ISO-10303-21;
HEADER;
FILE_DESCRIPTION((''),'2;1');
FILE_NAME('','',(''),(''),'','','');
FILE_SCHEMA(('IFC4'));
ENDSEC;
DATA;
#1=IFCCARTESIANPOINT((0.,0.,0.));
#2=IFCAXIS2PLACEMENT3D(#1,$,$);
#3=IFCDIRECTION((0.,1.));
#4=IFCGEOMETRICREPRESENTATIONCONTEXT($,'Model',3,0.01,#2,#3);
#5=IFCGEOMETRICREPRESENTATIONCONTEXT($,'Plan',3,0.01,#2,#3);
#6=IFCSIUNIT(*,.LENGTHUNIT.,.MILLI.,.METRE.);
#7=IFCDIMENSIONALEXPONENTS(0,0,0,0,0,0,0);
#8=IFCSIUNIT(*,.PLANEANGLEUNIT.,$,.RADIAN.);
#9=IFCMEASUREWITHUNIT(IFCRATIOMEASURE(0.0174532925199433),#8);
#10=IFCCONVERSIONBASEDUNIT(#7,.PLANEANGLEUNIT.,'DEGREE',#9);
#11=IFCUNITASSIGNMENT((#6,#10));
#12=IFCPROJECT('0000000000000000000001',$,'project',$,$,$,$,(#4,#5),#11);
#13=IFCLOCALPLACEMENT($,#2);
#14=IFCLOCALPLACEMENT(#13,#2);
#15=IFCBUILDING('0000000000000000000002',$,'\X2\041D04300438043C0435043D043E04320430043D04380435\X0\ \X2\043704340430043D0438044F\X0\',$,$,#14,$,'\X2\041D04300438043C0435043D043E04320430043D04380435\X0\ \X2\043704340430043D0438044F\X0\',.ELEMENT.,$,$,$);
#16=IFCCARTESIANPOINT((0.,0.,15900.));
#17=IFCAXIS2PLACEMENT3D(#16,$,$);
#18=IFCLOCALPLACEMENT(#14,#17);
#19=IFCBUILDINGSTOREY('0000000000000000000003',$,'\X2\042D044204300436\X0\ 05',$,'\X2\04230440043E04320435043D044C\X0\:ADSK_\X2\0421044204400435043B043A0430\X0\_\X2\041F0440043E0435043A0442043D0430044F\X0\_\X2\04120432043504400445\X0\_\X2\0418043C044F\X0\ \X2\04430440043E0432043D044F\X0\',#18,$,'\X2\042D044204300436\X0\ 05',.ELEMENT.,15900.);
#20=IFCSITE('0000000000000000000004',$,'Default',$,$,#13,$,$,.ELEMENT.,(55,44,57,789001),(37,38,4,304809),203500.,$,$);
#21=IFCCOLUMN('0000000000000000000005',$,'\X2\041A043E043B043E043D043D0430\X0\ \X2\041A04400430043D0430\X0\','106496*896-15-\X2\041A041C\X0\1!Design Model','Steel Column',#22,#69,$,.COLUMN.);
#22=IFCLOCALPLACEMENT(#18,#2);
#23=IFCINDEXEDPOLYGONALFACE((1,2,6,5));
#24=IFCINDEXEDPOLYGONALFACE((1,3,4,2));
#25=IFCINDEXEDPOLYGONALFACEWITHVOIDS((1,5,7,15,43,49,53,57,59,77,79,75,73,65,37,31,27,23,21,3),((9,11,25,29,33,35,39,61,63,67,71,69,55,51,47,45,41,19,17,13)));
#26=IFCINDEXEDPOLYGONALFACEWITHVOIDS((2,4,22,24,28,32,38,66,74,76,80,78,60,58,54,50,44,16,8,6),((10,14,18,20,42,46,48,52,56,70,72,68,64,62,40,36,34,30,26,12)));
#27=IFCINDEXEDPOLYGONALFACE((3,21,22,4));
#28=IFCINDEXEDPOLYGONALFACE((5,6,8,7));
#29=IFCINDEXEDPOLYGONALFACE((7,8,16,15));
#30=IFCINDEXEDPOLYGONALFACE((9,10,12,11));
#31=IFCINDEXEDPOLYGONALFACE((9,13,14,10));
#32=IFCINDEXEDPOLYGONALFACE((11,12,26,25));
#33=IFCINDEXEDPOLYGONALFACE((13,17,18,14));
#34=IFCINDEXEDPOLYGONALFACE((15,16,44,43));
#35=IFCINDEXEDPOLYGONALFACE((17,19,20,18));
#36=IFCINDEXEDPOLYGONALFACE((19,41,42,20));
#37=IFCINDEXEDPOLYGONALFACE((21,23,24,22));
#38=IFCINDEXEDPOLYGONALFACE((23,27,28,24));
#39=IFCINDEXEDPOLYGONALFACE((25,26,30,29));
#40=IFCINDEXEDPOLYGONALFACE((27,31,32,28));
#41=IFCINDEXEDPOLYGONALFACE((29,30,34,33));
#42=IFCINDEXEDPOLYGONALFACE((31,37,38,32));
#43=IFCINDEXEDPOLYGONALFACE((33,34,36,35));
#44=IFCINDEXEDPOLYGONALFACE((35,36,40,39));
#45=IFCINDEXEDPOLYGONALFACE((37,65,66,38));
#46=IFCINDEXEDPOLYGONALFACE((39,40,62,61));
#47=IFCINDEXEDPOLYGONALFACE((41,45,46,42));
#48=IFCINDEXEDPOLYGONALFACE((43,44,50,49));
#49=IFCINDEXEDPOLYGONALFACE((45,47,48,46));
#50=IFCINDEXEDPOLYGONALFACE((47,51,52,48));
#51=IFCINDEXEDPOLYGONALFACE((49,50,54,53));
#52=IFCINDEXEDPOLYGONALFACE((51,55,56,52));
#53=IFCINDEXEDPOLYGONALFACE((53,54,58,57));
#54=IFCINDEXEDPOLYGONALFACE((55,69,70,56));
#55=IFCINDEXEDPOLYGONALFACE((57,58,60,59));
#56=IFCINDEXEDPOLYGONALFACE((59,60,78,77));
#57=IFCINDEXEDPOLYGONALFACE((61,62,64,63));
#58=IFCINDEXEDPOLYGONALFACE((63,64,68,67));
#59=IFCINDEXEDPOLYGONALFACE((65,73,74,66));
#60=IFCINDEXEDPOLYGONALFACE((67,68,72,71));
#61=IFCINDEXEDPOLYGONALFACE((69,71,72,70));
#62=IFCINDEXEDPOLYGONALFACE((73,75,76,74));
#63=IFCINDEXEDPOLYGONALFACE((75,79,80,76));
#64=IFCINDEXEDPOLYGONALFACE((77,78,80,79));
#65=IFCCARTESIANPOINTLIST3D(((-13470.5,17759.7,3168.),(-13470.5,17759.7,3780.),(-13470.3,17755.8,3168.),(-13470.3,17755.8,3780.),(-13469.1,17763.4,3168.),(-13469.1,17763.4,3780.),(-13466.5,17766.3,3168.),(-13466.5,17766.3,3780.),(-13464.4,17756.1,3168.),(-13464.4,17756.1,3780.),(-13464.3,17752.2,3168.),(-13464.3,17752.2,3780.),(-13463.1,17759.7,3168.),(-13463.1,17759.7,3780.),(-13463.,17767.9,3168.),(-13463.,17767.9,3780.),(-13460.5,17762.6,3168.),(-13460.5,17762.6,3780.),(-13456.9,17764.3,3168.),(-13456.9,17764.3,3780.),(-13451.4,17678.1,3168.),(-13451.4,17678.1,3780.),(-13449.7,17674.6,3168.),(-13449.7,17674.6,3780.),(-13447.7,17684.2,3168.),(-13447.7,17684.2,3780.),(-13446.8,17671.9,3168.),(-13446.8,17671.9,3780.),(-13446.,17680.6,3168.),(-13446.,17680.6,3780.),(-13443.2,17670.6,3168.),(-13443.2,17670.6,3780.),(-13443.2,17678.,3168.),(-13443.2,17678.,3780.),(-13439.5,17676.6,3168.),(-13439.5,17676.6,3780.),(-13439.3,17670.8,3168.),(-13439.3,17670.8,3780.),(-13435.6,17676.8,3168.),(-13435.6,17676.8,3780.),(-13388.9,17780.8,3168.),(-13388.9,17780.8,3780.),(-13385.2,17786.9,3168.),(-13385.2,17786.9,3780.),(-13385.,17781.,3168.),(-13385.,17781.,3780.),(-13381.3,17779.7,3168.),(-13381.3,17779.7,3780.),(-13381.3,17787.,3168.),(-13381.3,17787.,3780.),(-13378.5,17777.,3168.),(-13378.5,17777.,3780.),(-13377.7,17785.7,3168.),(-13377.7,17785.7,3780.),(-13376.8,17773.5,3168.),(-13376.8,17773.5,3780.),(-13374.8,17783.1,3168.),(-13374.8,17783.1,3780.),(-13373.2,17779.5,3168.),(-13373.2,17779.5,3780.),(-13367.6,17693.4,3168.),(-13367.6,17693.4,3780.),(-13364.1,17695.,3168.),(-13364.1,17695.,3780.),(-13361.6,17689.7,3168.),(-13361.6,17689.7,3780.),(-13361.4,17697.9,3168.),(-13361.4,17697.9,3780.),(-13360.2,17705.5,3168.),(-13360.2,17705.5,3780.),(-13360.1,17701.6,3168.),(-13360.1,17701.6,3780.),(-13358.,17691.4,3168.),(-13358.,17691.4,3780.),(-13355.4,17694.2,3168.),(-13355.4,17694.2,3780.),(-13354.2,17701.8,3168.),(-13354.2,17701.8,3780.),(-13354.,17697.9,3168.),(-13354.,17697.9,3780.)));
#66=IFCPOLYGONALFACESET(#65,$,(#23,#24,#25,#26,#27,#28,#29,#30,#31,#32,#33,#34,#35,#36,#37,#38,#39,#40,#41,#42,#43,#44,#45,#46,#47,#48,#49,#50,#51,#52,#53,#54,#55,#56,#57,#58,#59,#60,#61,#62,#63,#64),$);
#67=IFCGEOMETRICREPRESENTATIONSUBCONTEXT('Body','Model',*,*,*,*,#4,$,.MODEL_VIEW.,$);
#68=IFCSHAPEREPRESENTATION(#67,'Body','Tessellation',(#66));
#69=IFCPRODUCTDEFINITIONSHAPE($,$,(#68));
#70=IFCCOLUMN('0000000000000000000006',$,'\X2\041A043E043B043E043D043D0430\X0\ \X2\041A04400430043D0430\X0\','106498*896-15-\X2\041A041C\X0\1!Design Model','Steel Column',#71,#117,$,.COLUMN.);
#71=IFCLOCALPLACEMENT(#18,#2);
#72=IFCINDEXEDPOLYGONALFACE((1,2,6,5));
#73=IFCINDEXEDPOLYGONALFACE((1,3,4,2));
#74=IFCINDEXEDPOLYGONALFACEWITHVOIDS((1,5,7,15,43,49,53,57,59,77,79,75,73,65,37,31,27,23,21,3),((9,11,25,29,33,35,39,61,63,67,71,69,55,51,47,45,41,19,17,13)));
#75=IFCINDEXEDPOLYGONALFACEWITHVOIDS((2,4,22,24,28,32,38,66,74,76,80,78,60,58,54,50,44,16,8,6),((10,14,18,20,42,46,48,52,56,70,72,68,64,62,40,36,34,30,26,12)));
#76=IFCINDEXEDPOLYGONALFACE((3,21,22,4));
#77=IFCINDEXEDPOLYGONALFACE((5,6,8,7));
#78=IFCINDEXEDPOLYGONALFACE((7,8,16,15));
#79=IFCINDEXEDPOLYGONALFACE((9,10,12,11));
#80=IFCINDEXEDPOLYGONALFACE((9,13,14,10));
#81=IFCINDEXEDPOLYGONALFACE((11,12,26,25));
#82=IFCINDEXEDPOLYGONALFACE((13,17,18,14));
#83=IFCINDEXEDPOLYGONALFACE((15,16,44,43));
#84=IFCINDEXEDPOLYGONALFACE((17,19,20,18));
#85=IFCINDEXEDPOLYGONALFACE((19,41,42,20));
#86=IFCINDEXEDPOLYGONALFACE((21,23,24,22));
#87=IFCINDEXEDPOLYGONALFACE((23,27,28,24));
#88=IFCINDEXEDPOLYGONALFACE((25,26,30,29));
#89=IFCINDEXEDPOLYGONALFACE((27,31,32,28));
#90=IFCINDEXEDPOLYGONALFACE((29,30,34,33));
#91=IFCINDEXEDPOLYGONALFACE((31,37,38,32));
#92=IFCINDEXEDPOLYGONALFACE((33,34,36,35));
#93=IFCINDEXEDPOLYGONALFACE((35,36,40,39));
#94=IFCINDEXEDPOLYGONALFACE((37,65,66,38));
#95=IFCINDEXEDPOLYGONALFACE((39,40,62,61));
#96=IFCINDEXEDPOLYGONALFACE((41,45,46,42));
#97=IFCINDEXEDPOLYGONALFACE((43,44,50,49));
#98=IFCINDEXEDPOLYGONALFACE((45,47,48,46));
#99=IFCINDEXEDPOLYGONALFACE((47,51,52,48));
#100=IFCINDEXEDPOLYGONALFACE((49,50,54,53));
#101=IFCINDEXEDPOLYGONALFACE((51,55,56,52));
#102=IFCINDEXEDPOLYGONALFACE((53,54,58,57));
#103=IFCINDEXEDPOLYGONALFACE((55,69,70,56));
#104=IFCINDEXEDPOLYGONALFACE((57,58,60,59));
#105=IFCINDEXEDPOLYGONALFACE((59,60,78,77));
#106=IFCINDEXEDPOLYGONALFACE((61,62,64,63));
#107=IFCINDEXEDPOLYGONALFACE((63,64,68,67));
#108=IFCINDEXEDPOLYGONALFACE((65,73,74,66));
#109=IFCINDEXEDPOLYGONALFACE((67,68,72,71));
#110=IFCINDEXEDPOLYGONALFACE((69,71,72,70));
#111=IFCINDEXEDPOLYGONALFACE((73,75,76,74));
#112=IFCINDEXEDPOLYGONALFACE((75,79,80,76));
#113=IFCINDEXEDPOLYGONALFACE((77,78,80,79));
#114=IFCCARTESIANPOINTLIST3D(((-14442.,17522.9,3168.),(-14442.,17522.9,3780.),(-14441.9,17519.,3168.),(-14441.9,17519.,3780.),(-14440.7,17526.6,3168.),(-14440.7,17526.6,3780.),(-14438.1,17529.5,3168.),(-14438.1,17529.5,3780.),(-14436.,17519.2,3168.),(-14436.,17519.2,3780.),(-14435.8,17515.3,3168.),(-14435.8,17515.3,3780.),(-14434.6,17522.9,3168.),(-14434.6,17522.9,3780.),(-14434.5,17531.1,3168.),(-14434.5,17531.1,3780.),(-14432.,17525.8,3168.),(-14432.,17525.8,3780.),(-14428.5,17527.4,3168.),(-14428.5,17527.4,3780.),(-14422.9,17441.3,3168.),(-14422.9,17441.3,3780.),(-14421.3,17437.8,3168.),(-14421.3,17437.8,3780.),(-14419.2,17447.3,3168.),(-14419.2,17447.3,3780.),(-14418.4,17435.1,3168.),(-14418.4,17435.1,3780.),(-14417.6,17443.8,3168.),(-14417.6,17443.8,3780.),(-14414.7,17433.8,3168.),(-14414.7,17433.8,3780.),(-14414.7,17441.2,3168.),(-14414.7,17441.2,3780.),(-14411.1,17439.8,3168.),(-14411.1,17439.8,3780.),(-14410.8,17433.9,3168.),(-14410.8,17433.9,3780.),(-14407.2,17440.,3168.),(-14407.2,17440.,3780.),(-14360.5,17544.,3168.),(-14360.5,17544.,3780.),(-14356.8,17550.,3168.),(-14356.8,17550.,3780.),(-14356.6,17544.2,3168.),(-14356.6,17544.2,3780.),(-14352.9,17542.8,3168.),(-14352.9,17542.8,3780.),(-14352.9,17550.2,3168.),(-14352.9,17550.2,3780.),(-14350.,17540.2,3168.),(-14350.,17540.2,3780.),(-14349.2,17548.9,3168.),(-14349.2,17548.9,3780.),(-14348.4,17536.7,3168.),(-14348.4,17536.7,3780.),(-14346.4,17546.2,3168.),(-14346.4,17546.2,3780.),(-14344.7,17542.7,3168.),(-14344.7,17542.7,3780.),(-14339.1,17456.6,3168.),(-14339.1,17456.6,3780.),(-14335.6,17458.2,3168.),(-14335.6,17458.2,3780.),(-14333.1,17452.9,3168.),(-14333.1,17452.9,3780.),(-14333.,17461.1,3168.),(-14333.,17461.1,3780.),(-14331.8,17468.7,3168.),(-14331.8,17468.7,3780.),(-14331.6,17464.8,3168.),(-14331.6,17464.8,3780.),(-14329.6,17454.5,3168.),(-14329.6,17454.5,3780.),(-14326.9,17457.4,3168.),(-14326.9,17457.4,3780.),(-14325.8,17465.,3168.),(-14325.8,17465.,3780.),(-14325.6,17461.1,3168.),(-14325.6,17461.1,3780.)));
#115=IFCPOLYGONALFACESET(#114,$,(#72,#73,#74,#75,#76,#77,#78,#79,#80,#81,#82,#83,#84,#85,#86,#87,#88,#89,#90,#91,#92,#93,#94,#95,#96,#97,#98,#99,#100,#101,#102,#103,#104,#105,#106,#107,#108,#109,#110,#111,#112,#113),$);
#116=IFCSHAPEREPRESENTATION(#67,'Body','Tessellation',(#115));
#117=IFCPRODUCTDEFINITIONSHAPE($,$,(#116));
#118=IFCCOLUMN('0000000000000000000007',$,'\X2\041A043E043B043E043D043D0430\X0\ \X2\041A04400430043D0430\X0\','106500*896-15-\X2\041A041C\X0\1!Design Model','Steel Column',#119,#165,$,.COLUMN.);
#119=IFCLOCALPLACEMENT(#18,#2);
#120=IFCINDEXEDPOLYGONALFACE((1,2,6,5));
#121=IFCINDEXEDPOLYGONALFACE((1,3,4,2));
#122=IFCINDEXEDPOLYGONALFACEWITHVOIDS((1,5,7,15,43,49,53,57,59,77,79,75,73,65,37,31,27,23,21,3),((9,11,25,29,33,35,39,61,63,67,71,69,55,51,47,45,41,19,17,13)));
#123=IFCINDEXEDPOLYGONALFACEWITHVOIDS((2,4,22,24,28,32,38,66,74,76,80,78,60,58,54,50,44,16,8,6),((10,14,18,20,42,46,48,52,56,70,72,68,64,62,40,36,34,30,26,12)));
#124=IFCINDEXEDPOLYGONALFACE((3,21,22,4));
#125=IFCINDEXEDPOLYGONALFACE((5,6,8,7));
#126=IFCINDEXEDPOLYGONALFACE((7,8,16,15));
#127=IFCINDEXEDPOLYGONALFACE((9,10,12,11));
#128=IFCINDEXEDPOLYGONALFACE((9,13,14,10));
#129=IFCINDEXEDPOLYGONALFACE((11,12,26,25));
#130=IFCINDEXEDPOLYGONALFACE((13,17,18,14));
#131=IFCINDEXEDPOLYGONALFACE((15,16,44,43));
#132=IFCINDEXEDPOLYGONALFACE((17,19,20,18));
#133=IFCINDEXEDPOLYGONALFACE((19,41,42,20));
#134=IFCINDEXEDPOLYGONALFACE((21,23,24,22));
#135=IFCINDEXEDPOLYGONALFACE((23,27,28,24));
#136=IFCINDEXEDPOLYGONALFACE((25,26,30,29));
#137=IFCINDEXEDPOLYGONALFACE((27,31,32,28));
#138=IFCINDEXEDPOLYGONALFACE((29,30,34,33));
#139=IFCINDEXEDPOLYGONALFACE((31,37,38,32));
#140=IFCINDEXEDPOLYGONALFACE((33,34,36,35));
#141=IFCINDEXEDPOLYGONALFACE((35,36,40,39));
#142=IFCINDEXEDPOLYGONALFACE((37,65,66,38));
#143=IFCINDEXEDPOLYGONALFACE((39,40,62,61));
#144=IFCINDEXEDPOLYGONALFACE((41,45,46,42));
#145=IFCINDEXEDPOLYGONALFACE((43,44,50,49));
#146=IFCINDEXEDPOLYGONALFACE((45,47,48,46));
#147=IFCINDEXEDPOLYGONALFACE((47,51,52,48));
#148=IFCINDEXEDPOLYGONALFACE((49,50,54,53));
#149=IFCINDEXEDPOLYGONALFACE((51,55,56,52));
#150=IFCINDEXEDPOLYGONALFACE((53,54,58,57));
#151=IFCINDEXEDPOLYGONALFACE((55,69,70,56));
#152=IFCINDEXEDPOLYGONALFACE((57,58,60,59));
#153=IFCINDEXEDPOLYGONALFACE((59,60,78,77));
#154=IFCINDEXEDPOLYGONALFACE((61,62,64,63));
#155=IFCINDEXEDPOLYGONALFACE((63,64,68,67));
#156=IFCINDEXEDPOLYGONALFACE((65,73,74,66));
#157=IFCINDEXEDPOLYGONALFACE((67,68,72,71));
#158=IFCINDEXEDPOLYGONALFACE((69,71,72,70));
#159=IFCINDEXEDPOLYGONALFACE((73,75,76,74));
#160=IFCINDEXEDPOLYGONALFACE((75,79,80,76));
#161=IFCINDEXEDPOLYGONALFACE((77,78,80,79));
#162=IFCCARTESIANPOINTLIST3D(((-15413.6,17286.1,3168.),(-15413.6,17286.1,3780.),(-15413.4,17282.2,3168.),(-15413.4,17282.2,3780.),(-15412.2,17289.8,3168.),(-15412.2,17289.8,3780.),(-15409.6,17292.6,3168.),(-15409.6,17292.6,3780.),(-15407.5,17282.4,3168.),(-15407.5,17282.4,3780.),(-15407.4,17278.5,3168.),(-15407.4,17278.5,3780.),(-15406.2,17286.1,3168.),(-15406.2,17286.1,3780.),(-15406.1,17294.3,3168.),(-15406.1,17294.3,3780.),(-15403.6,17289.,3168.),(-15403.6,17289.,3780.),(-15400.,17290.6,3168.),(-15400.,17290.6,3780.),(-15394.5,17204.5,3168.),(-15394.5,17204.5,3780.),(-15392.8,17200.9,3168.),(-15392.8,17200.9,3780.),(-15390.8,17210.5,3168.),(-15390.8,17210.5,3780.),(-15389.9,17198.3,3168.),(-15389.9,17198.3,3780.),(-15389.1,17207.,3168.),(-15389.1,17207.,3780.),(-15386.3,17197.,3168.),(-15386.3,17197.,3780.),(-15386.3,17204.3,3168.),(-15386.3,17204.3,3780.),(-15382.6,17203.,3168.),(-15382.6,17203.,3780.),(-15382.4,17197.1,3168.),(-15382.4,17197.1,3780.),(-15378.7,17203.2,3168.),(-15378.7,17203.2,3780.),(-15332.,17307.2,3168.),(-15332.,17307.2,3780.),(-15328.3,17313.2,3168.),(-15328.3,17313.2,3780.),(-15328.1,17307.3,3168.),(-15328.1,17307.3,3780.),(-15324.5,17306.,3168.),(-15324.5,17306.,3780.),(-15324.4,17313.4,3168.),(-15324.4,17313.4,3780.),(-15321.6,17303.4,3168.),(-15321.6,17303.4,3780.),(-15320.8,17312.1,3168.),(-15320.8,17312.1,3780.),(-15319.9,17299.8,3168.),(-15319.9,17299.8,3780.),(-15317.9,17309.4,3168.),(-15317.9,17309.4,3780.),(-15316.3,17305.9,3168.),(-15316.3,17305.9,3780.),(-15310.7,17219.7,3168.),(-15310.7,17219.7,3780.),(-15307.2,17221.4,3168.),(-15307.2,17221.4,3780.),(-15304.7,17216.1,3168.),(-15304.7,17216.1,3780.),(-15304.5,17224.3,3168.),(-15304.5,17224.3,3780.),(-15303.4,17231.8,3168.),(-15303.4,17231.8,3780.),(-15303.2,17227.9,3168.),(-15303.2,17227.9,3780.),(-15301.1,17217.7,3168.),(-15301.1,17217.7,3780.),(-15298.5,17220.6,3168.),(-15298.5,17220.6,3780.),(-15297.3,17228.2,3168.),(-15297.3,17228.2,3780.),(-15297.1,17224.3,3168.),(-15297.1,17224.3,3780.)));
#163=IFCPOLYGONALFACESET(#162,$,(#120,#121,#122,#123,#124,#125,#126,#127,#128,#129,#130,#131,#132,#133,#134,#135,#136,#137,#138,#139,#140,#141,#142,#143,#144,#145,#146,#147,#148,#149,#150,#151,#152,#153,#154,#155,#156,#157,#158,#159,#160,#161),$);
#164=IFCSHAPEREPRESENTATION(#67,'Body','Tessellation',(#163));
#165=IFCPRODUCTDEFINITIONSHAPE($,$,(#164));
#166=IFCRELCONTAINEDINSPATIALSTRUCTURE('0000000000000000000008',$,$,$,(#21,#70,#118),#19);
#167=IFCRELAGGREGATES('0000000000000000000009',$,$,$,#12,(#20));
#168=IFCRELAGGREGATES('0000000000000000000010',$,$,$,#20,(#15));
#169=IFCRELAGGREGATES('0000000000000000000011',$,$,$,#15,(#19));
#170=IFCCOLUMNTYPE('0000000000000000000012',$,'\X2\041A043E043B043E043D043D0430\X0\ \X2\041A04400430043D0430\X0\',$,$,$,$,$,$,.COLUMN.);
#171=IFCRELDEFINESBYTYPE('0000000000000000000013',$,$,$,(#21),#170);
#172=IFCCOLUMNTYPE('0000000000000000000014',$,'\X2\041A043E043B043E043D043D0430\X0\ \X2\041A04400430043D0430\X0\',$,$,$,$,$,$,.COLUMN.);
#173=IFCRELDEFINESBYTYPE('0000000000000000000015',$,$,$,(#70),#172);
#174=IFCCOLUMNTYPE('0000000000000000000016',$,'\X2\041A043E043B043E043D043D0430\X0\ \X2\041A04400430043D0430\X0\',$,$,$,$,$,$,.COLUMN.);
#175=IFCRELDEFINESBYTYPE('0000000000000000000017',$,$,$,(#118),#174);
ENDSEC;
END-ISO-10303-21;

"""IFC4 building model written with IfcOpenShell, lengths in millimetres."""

from ifc_helpers import new_model, entity, si_unit, converted_unit, direction, frame, origin, place, context, subcontext, project, spatial, indexed_curve, outline, extrude, type_object, element, save


model = new_model("IFC4")

# Units and contexts
model_context = context("Model", 3, precision=0.01, world=origin(), true_north=direction((0.0, 1.0)))
plan_context = context("Plan", 3, precision=0.01, world=origin(), true_north=direction((0.0, 1.0)))
body_context = subcontext(model_context, "Body", "Model", "MODEL_VIEW")
ifc_project = project(units=[si_unit("LENGTHUNIT", "METRE", prefix="MILLI"), converted_unit("PLANEANGLEUNIT", "DEGREE", entity("IfcRatioMeasure", 0.0174532925199433), si_unit("PLANEANGLEUNIT", "RADIAN"), dimensions=[0, 0, 0, 0, 0, 0, 0])], contexts=[model_context, plan_context])

# Site, building, storey
site_placement = place(None, origin())
site = spatial("IfcSite", under=ifc_project, at=site_placement, Name="Default", CompositionType="ELEMENT", RefLatitude=(55, 44, 57, 789001), RefLongitude=(37, 38, 4, 304809), RefElevation=203500.0)
building_placement = place(site_placement, origin())
building = spatial("IfcBuilding", under=site, at=building_placement, Name="Наименование здания", LongName="Наименование здания", CompositionType="ELEMENT")
storey_placement = place(building_placement, frame((0.0, 0.0, 15900.0)))
storey = spatial("IfcBuildingStorey", under=building, at=storey_placement, Name="Этаж 05", ObjectType="Уровень:ADSK_Стрелка_Проектная_Вверх_Имя уровня", LongName="Этаж 05", CompositionType="ELEMENT", Elevation=15900.0)

# Columns
column_type_1 = type_object("IfcColumnType", Name="Колонна Крана", PredefinedType="COLUMN")
column_1_placement = place(storey_placement, origin())
element("IfcColumn", 1, at=column_1_placement, inside=storey, type_object=column_type_1, Name="Колонна Крана", Description="106496*896-15-КМ1!Design Model", ObjectType="Steel Column", PredefinedType="COLUMN", context=body_context, shape_type="SweptSolid", body=[
    extrude(outline(indexed_curve([(29.5, -56.8), (33.4, -56.8), (37.0, -55.3), (39.7, -52.6), (41.2, -49.0), (56.8, 29.5), (56.8, 33.4), (55.3, 37.0), (52.6, 39.7), (49.0, 41.2), (-29.5, 56.8), (-33.4, 56.8), (-37.0, 55.3), (-39.7, 52.6), (-41.2, 49.0), (-56.8, -29.5), (-56.8, -33.4), (-55.3, -37.0), (-52.6, -39.7), (-49.0, -41.2), (29.5, -56.8)], self_intersect=False), holes=[indexed_curve([(-43.1, -37.3), (-46.7, -35.8), (-49.5, -33.1), (-51.0, -29.5), (-51.0, -25.5), (-37.3, 43.1), (-35.8, 46.7), (-33.1, 49.5), (-29.5, 51.0), (-25.5, 51.0), (43.1, 37.3), (46.7, 35.8), (49.5, 33.1), (51.0, 29.5), (51.0, 25.5), (37.3, -43.1), (35.8, -46.7), (33.1, -49.5), (29.5, -51.0), (25.5, -51.0), (-43.1, -37.3)], self_intersect=False)]), frame((-13412.3, 17728.8, 3168.0), z_axis=(0.0, 0.0, 1.0), x_axis=(0.906681, 0.421816, 0.0)), (0.0, 0.0, 1.0), 612.0),
])
column_type_2 = type_object("IfcColumnType", Name="Колонна Крана", PredefinedType="COLUMN")
column_2_placement = place(storey_placement, origin())
element("IfcColumn", 2, at=column_2_placement, inside=storey, type_object=column_type_2, Name="Колонна Крана", Description="106498*896-15-КМ1!Design Model", ObjectType="Steel Column", PredefinedType="COLUMN", context=body_context, shape_type="SweptSolid", body=[
    extrude(outline(indexed_curve([(29.5, -56.8), (33.4, -56.8), (37.0, -55.3), (39.7, -52.6), (41.2, -49.0), (56.8, 29.5), (56.8, 33.4), (55.3, 37.0), (52.6, 39.7), (49.0, 41.2), (-29.5, 56.8), (-33.4, 56.8), (-37.0, 55.3), (-39.7, 52.6), (-41.2, 49.0), (-56.8, -29.5), (-56.8, -33.4), (-55.3, -37.0), (-52.6, -39.7), (-49.0, -41.2), (29.5, -56.8)], self_intersect=False), holes=[indexed_curve([(-43.1, -37.3), (-46.7, -35.8), (-49.5, -33.1), (-51.0, -29.5), (-51.0, -25.5), (-37.3, 43.1), (-35.8, 46.7), (-33.1, 49.5), (-29.5, 51.0), (-25.5, 51.0), (43.1, 37.3), (46.7, 35.8), (49.5, 33.1), (51.0, 29.5), (51.0, 25.5), (37.3, -43.1), (35.8, -46.7), (33.1, -49.5), (29.5, -51.0), (25.5, -51.0), (-43.1, -37.3)], self_intersect=False)]), frame((-14383.8, 17492.0, 3168.0), z_axis=(0.0, 0.0, 1.0), x_axis=(0.906681, 0.421816, 0.0)), (0.0, 0.0, 1.0), 612.0),
])
column_type_3 = type_object("IfcColumnType", Name="Колонна Крана", PredefinedType="COLUMN")
column_3_placement = place(storey_placement, origin())
element("IfcColumn", 3, at=column_3_placement, inside=storey, type_object=column_type_3, Name="Колонна Крана", Description="106500*896-15-КМ1!Design Model", ObjectType="Steel Column", PredefinedType="COLUMN", context=body_context, shape_type="SweptSolid", body=[
    extrude(outline(indexed_curve([(29.5, -56.8), (33.4, -56.8), (37.0, -55.3), (39.7, -52.6), (41.2, -49.0), (56.8, 29.5), (56.8, 33.4), (55.3, 37.0), (52.6, 39.7), (49.0, 41.2), (-29.5, 56.8), (-33.4, 56.8), (-37.0, 55.3), (-39.7, 52.6), (-41.2, 49.0), (-56.8, -29.5), (-56.8, -33.4), (-55.3, -37.0), (-52.6, -39.7), (-49.0, -41.2), (29.5, -56.8)], self_intersect=False), holes=[indexed_curve([(-43.1, -37.3), (-46.7, -35.8), (-49.5, -33.1), (-51.0, -29.5), (-51.0, -25.5), (-37.3, 43.1), (-35.8, 46.7), (-33.1, 49.5), (-29.5, 51.0), (-25.5, 51.0), (43.1, 37.3), (46.7, 35.8), (49.5, 33.1), (51.0, 29.5), (51.0, 25.5), (37.3, -43.1), (35.8, -46.7), (33.1, -49.5), (29.5, -51.0), (25.5, -51.0), (-43.1, -37.3)], self_intersect=False)]), frame((-15355.4, 17255.2, 3168.0), z_axis=(0.0, 0.0, 1.0), x_axis=(0.906681, 0.421816, 0.0)), (0.0, 0.0, 1.0), 612.0),
])

save(model, "model.ifc")
